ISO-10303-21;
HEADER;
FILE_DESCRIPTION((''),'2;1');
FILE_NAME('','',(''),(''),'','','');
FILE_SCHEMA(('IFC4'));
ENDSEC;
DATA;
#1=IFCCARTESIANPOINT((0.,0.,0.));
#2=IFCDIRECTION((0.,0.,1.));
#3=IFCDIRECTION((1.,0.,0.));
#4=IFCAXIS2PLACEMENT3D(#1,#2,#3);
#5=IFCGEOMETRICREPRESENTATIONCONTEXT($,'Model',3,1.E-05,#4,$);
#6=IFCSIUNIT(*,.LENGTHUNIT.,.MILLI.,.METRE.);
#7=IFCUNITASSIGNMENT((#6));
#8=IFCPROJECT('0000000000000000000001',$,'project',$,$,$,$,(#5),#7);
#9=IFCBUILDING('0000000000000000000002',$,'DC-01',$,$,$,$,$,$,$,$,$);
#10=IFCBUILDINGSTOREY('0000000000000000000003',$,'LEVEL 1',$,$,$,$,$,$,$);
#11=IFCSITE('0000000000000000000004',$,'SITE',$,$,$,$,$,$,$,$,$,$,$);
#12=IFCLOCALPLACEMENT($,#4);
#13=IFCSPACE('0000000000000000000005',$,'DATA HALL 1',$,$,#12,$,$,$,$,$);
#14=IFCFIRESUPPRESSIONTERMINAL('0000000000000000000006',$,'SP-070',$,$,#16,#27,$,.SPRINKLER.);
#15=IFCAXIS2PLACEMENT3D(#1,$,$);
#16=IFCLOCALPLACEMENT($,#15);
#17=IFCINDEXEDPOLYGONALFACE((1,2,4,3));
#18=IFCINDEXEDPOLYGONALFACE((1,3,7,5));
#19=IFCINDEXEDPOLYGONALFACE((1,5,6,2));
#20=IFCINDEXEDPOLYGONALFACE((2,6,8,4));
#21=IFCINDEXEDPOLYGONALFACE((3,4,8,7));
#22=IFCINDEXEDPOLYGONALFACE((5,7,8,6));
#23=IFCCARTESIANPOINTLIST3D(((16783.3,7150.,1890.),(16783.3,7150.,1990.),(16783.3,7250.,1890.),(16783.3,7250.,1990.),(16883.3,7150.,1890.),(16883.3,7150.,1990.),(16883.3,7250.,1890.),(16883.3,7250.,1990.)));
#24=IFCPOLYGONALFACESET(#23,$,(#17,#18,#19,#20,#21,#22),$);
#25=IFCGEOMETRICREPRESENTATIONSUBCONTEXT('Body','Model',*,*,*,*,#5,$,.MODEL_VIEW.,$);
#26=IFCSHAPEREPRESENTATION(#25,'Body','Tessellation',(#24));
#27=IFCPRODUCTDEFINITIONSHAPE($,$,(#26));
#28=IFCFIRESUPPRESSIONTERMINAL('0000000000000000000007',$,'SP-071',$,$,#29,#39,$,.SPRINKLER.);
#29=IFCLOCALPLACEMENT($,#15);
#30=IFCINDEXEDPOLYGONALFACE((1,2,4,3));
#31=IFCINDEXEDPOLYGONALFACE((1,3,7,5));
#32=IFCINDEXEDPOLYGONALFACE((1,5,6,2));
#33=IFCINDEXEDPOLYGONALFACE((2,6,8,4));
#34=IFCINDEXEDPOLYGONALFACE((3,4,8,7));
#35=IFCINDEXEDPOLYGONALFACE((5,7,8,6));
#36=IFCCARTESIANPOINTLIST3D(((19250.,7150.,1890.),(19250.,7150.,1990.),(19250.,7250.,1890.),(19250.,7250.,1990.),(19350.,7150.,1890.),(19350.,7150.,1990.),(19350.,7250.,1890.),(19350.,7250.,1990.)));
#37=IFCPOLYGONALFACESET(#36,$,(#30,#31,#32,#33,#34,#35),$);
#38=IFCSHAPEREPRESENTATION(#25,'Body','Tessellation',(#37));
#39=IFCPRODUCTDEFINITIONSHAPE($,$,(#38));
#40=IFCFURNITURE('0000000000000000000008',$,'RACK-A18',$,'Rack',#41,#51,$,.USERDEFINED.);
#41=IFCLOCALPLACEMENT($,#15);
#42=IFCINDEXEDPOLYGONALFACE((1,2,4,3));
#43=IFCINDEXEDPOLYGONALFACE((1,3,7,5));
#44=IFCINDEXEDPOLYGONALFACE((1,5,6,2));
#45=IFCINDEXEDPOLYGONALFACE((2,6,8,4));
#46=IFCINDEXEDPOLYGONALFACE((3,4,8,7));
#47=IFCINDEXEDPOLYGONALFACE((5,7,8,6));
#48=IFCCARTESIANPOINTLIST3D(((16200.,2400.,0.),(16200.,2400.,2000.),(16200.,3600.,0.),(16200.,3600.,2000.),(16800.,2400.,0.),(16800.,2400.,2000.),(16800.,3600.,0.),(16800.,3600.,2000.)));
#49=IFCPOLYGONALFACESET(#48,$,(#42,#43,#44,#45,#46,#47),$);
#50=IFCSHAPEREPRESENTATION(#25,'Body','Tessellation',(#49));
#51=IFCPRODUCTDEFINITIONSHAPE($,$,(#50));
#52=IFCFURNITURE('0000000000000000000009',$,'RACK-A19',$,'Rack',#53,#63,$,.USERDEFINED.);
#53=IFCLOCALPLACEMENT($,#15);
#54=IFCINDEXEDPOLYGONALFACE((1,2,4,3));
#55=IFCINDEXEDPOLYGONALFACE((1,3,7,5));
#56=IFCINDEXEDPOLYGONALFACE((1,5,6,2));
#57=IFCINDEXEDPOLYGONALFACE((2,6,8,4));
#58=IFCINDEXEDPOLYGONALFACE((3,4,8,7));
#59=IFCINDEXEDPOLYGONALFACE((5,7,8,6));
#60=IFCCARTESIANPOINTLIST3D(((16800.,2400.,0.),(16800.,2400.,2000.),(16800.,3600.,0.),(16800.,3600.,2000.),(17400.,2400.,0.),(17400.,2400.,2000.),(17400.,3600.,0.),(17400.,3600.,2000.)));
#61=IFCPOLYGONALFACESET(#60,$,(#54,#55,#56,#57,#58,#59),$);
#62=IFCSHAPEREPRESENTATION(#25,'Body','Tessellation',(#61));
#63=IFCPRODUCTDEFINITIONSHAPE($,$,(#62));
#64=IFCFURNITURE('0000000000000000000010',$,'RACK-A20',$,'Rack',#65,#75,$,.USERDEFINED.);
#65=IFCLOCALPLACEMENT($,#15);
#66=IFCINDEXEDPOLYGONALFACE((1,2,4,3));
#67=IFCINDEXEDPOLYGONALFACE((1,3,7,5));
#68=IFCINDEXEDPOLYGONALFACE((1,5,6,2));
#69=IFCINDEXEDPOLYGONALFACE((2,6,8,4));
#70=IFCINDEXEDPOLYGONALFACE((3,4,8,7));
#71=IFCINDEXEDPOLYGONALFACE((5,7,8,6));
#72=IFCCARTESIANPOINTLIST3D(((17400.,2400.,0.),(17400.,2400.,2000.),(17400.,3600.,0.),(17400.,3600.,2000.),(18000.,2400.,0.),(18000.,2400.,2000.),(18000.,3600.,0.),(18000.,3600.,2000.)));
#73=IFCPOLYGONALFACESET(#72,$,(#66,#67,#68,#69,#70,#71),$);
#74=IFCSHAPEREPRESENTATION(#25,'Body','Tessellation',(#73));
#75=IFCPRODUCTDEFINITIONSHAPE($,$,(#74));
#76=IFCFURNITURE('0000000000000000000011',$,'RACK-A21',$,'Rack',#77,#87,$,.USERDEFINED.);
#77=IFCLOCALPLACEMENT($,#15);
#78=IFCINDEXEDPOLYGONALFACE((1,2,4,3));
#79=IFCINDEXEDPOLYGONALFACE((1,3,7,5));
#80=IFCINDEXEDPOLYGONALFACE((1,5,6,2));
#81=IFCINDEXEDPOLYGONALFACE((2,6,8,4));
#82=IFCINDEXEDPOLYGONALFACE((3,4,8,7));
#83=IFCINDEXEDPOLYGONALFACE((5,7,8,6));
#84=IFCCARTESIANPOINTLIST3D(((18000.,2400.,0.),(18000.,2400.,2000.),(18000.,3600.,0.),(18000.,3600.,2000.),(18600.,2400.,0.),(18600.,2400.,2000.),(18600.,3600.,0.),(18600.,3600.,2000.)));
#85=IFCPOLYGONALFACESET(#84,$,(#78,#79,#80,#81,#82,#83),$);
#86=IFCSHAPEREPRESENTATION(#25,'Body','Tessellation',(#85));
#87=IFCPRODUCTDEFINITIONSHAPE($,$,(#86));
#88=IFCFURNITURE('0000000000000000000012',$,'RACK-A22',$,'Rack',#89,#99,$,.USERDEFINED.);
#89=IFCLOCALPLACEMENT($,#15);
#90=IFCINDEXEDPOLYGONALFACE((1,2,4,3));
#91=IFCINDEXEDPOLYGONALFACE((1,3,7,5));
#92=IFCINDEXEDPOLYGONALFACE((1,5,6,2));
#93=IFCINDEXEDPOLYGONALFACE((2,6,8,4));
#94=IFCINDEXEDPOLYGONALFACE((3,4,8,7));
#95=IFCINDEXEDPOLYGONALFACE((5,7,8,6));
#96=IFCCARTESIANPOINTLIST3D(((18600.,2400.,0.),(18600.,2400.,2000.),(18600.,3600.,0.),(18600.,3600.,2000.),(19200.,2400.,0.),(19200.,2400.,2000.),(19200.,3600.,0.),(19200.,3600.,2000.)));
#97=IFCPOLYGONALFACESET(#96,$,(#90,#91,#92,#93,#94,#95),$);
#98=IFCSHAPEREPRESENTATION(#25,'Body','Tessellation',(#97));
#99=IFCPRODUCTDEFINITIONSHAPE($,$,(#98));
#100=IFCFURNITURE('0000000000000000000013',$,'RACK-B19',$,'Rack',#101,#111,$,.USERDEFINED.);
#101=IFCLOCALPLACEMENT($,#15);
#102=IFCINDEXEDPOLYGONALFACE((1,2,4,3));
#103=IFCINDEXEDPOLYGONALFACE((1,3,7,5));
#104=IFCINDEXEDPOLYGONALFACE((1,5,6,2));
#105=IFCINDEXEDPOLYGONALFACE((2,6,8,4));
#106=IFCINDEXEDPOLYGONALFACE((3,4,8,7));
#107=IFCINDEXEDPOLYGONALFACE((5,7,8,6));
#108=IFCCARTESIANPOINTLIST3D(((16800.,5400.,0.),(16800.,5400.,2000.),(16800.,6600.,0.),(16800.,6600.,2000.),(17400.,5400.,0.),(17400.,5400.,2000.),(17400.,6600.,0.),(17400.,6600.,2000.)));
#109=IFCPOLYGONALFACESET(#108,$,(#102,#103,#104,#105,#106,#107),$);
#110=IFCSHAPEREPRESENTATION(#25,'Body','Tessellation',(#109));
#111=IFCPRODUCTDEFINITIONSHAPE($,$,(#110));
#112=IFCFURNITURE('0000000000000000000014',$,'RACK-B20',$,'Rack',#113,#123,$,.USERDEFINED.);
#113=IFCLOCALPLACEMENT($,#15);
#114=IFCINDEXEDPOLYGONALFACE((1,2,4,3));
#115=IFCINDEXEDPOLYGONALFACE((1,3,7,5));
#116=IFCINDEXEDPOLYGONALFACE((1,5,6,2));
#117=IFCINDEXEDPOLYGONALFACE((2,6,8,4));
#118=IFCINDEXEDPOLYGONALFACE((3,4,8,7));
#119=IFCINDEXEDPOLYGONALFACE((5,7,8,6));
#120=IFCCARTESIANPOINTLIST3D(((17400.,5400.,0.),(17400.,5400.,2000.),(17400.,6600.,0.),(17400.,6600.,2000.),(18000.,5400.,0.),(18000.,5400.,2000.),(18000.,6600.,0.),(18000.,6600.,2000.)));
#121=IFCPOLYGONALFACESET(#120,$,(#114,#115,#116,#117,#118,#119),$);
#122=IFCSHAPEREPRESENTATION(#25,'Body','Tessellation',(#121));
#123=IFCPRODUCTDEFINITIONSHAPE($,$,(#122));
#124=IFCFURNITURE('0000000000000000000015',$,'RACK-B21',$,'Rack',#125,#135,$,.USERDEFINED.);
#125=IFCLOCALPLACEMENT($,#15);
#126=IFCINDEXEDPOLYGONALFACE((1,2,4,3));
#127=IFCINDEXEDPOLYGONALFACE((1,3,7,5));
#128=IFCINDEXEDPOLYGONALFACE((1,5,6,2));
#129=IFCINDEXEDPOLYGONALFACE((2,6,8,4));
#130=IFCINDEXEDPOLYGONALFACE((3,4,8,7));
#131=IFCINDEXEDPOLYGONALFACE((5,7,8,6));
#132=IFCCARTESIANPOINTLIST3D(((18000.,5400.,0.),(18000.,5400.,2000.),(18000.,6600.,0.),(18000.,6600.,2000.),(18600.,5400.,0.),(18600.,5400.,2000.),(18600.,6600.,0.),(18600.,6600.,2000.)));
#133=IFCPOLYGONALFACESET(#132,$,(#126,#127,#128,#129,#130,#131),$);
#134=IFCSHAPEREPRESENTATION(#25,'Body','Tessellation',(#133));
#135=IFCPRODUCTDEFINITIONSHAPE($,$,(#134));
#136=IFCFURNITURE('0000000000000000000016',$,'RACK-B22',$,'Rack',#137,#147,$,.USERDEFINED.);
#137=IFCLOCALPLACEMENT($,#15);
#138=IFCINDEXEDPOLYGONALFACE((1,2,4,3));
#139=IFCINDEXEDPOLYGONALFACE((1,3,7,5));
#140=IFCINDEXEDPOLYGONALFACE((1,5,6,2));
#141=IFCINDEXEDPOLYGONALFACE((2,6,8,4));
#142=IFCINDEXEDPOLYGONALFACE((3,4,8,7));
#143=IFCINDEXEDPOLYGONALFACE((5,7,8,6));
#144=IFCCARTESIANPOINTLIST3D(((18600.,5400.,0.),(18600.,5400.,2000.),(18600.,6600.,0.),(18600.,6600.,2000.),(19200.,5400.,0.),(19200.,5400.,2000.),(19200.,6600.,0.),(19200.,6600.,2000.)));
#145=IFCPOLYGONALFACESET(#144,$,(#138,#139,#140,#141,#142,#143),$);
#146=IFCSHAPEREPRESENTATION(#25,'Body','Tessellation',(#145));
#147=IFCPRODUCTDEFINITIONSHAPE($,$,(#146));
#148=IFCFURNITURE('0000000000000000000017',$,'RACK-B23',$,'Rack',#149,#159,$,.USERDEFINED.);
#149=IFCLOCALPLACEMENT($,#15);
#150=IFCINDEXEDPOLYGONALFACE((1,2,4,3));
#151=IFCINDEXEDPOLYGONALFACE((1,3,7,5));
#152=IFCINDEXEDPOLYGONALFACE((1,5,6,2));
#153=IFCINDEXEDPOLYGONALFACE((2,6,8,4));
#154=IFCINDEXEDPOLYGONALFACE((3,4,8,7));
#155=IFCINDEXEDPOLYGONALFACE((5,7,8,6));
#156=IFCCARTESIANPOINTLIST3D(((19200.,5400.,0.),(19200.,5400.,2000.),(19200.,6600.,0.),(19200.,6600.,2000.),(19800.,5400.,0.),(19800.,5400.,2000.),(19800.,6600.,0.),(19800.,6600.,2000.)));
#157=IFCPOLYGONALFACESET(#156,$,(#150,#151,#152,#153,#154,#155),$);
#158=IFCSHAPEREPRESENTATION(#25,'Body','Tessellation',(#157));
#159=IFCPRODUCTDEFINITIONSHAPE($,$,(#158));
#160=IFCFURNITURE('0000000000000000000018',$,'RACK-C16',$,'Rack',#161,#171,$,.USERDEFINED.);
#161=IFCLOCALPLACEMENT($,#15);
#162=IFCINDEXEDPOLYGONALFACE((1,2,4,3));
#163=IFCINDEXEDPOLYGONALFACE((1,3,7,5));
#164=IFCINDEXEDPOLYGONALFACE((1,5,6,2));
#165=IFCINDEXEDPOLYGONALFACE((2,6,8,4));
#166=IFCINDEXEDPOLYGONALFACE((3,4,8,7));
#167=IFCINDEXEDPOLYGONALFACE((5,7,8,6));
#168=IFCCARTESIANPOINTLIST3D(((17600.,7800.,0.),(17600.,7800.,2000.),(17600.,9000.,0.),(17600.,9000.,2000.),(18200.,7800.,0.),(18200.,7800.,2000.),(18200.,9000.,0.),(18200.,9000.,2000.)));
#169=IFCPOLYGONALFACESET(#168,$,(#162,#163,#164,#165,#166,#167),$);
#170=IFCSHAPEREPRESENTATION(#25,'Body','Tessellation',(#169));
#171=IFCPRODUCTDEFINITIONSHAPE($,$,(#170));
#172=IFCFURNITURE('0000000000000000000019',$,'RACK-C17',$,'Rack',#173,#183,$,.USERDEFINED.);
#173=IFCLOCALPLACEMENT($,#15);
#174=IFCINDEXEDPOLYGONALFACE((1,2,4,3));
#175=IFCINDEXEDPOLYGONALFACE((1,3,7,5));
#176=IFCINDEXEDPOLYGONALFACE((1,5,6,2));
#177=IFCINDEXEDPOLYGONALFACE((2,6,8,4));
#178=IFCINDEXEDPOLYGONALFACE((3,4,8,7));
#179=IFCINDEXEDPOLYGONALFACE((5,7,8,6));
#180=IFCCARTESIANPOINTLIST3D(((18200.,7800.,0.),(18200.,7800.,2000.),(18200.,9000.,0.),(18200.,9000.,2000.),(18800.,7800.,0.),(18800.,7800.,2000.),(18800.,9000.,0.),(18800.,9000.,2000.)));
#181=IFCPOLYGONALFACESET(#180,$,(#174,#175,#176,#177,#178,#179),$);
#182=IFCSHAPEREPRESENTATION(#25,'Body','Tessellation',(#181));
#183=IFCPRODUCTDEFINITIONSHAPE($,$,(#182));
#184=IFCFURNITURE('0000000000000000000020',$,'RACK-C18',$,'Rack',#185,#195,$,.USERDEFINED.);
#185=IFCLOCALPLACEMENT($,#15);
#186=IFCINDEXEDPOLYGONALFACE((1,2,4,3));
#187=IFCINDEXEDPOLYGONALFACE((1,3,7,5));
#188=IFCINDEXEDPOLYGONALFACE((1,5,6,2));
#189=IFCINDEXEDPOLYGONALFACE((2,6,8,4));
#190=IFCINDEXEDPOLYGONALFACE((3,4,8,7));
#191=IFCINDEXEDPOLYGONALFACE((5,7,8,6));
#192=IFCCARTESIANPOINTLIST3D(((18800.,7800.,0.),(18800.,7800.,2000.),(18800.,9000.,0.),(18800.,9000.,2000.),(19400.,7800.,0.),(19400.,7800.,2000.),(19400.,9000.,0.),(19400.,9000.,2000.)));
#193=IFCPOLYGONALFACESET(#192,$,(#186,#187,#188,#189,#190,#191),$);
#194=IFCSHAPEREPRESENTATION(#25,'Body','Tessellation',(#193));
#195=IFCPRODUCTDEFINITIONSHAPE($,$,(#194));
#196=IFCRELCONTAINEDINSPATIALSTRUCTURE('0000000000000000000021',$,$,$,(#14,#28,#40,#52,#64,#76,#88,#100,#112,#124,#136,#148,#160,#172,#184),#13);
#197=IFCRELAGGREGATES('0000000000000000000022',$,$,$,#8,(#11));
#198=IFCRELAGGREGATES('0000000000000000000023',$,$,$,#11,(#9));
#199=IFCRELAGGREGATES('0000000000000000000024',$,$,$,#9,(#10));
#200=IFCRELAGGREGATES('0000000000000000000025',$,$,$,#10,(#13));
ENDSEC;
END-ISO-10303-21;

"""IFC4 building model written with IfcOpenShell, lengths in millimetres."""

from ifc_helpers import new_model, si_unit, frame, origin, origin_with_axes, place, context, subcontext, project, spatial, polyline, outline, extrude, element, save


model = new_model("IFC4")

# Units and contexts
model_context = context("Model", 3, precision=1e-05, world=origin_with_axes())
body_context = subcontext(model_context, "Body", "Model", "MODEL_VIEW")
ifc_project = project(units=[si_unit("LENGTHUNIT", "METRE", prefix="MILLI")], contexts=[model_context])

# Site, building, storey, space
site = spatial("IfcSite", under=ifc_project, Name="SITE")
building = spatial("IfcBuilding", under=site, Name="DC-01")
storey = spatial("IfcBuildingStorey", under=building, Name="LEVEL 1")
space_placement = place(None, origin_with_axes())
space = spatial("IfcSpace", under=storey, at=space_placement, Name="DATA HALL 1")

# Fire suppression terminals
for number, where, z_axis, x_axis, name in (
    (1, (16783.3, 7150.0, 1890.0), (0.0, 0.0, 1.0), (1.0, 0.0, 0.0), "SP-070"),
    (2, (19250.0, 7150.0, 1890.0), (0.0, 0.0, 1.0), (1.0, 0.0, 0.0), "SP-071"),
):
    element("IfcFireSuppressionTerminal", number, at=place(space_placement, frame(where, z_axis=z_axis, x_axis=x_axis)), inside=space, Name=name, PredefinedType="SPRINKLER", context=body_context, shape_type="SweptSolid", body=[
        extrude(outline(polyline([(0.0, 0.0), (100.0, 0.0), (100.0, 100.0), (0.0, 100.0), (0.0, 0.0)])), origin(), (0.0, 0.0, 1.0), 100.0),
    ])

# Furniture
for number, where, z_axis, x_axis, name in (
    (3, (16800.0, 3600.0, 0.0), (0.0, 0.0, 1.0), (-1.0, 0.0, 0.0), "RACK-A18"),
    (4, (17400.0, 3600.0, 0.0), (0.0, 0.0, 1.0), (-1.0, 0.0, 0.0), "RACK-A19"),
    (5, (18000.0, 3600.0, 0.0), (0.0, 0.0, 1.0), (-1.0, 0.0, 0.0), "RACK-A20"),
    (6, (18600.0, 3600.0, 0.0), (0.0, 0.0, 1.0), (-1.0, 0.0, 0.0), "RACK-A21"),
    (7, (19200.0, 3600.0, 0.0), (0.0, 0.0, 1.0), (-1.0, 0.0, 0.0), "RACK-A22"),
    (8, (16800.0, 5400.0, 0.0), (0.0, 0.0, 1.0), (1.0, 0.0, 0.0), "RACK-B19"),
    (9, (17400.0, 5400.0, 0.0), (0.0, 0.0, 1.0), (1.0, 0.0, 0.0), "RACK-B20"),
    (10, (18000.0, 5400.0, 0.0), (0.0, 0.0, 1.0), (1.0, 0.0, 0.0), "RACK-B21"),
    (11, (18600.0, 5400.0, 0.0), (0.0, 0.0, 1.0), (1.0, 0.0, 0.0), "RACK-B22"),
    (12, (19200.0, 5400.0, 0.0), (0.0, 0.0, 1.0), (1.0, 0.0, 0.0), "RACK-B23"),
    (13, (18200.0, 9000.0, 0.0), (0.0, 0.0, 1.0), (-1.0, 0.0, 0.0), "RACK-C16"),
    (14, (18800.0, 9000.0, 0.0), (0.0, 0.0, 1.0), (-1.0, 0.0, 0.0), "RACK-C17"),
    (15, (19400.0, 9000.0, 0.0), (0.0, 0.0, 1.0), (-1.0, 0.0, 0.0), "RACK-C18"),
):
    element("IfcFurniture", number, at=place(space_placement, frame(where, z_axis=z_axis, x_axis=x_axis)), inside=space, Name=name, ObjectType="Rack", PredefinedType="USERDEFINED", context=body_context, shape_type="SweptSolid", body=[
        extrude(outline(polyline([(0.0, 0.0), (600.0, 0.0), (600.0, 1200.0), (0.0, 1200.0), (0.0, 0.0)])), origin(), (0.0, 0.0, 1.0), 2000.0),
    ])

save(model, "model.ifc")
